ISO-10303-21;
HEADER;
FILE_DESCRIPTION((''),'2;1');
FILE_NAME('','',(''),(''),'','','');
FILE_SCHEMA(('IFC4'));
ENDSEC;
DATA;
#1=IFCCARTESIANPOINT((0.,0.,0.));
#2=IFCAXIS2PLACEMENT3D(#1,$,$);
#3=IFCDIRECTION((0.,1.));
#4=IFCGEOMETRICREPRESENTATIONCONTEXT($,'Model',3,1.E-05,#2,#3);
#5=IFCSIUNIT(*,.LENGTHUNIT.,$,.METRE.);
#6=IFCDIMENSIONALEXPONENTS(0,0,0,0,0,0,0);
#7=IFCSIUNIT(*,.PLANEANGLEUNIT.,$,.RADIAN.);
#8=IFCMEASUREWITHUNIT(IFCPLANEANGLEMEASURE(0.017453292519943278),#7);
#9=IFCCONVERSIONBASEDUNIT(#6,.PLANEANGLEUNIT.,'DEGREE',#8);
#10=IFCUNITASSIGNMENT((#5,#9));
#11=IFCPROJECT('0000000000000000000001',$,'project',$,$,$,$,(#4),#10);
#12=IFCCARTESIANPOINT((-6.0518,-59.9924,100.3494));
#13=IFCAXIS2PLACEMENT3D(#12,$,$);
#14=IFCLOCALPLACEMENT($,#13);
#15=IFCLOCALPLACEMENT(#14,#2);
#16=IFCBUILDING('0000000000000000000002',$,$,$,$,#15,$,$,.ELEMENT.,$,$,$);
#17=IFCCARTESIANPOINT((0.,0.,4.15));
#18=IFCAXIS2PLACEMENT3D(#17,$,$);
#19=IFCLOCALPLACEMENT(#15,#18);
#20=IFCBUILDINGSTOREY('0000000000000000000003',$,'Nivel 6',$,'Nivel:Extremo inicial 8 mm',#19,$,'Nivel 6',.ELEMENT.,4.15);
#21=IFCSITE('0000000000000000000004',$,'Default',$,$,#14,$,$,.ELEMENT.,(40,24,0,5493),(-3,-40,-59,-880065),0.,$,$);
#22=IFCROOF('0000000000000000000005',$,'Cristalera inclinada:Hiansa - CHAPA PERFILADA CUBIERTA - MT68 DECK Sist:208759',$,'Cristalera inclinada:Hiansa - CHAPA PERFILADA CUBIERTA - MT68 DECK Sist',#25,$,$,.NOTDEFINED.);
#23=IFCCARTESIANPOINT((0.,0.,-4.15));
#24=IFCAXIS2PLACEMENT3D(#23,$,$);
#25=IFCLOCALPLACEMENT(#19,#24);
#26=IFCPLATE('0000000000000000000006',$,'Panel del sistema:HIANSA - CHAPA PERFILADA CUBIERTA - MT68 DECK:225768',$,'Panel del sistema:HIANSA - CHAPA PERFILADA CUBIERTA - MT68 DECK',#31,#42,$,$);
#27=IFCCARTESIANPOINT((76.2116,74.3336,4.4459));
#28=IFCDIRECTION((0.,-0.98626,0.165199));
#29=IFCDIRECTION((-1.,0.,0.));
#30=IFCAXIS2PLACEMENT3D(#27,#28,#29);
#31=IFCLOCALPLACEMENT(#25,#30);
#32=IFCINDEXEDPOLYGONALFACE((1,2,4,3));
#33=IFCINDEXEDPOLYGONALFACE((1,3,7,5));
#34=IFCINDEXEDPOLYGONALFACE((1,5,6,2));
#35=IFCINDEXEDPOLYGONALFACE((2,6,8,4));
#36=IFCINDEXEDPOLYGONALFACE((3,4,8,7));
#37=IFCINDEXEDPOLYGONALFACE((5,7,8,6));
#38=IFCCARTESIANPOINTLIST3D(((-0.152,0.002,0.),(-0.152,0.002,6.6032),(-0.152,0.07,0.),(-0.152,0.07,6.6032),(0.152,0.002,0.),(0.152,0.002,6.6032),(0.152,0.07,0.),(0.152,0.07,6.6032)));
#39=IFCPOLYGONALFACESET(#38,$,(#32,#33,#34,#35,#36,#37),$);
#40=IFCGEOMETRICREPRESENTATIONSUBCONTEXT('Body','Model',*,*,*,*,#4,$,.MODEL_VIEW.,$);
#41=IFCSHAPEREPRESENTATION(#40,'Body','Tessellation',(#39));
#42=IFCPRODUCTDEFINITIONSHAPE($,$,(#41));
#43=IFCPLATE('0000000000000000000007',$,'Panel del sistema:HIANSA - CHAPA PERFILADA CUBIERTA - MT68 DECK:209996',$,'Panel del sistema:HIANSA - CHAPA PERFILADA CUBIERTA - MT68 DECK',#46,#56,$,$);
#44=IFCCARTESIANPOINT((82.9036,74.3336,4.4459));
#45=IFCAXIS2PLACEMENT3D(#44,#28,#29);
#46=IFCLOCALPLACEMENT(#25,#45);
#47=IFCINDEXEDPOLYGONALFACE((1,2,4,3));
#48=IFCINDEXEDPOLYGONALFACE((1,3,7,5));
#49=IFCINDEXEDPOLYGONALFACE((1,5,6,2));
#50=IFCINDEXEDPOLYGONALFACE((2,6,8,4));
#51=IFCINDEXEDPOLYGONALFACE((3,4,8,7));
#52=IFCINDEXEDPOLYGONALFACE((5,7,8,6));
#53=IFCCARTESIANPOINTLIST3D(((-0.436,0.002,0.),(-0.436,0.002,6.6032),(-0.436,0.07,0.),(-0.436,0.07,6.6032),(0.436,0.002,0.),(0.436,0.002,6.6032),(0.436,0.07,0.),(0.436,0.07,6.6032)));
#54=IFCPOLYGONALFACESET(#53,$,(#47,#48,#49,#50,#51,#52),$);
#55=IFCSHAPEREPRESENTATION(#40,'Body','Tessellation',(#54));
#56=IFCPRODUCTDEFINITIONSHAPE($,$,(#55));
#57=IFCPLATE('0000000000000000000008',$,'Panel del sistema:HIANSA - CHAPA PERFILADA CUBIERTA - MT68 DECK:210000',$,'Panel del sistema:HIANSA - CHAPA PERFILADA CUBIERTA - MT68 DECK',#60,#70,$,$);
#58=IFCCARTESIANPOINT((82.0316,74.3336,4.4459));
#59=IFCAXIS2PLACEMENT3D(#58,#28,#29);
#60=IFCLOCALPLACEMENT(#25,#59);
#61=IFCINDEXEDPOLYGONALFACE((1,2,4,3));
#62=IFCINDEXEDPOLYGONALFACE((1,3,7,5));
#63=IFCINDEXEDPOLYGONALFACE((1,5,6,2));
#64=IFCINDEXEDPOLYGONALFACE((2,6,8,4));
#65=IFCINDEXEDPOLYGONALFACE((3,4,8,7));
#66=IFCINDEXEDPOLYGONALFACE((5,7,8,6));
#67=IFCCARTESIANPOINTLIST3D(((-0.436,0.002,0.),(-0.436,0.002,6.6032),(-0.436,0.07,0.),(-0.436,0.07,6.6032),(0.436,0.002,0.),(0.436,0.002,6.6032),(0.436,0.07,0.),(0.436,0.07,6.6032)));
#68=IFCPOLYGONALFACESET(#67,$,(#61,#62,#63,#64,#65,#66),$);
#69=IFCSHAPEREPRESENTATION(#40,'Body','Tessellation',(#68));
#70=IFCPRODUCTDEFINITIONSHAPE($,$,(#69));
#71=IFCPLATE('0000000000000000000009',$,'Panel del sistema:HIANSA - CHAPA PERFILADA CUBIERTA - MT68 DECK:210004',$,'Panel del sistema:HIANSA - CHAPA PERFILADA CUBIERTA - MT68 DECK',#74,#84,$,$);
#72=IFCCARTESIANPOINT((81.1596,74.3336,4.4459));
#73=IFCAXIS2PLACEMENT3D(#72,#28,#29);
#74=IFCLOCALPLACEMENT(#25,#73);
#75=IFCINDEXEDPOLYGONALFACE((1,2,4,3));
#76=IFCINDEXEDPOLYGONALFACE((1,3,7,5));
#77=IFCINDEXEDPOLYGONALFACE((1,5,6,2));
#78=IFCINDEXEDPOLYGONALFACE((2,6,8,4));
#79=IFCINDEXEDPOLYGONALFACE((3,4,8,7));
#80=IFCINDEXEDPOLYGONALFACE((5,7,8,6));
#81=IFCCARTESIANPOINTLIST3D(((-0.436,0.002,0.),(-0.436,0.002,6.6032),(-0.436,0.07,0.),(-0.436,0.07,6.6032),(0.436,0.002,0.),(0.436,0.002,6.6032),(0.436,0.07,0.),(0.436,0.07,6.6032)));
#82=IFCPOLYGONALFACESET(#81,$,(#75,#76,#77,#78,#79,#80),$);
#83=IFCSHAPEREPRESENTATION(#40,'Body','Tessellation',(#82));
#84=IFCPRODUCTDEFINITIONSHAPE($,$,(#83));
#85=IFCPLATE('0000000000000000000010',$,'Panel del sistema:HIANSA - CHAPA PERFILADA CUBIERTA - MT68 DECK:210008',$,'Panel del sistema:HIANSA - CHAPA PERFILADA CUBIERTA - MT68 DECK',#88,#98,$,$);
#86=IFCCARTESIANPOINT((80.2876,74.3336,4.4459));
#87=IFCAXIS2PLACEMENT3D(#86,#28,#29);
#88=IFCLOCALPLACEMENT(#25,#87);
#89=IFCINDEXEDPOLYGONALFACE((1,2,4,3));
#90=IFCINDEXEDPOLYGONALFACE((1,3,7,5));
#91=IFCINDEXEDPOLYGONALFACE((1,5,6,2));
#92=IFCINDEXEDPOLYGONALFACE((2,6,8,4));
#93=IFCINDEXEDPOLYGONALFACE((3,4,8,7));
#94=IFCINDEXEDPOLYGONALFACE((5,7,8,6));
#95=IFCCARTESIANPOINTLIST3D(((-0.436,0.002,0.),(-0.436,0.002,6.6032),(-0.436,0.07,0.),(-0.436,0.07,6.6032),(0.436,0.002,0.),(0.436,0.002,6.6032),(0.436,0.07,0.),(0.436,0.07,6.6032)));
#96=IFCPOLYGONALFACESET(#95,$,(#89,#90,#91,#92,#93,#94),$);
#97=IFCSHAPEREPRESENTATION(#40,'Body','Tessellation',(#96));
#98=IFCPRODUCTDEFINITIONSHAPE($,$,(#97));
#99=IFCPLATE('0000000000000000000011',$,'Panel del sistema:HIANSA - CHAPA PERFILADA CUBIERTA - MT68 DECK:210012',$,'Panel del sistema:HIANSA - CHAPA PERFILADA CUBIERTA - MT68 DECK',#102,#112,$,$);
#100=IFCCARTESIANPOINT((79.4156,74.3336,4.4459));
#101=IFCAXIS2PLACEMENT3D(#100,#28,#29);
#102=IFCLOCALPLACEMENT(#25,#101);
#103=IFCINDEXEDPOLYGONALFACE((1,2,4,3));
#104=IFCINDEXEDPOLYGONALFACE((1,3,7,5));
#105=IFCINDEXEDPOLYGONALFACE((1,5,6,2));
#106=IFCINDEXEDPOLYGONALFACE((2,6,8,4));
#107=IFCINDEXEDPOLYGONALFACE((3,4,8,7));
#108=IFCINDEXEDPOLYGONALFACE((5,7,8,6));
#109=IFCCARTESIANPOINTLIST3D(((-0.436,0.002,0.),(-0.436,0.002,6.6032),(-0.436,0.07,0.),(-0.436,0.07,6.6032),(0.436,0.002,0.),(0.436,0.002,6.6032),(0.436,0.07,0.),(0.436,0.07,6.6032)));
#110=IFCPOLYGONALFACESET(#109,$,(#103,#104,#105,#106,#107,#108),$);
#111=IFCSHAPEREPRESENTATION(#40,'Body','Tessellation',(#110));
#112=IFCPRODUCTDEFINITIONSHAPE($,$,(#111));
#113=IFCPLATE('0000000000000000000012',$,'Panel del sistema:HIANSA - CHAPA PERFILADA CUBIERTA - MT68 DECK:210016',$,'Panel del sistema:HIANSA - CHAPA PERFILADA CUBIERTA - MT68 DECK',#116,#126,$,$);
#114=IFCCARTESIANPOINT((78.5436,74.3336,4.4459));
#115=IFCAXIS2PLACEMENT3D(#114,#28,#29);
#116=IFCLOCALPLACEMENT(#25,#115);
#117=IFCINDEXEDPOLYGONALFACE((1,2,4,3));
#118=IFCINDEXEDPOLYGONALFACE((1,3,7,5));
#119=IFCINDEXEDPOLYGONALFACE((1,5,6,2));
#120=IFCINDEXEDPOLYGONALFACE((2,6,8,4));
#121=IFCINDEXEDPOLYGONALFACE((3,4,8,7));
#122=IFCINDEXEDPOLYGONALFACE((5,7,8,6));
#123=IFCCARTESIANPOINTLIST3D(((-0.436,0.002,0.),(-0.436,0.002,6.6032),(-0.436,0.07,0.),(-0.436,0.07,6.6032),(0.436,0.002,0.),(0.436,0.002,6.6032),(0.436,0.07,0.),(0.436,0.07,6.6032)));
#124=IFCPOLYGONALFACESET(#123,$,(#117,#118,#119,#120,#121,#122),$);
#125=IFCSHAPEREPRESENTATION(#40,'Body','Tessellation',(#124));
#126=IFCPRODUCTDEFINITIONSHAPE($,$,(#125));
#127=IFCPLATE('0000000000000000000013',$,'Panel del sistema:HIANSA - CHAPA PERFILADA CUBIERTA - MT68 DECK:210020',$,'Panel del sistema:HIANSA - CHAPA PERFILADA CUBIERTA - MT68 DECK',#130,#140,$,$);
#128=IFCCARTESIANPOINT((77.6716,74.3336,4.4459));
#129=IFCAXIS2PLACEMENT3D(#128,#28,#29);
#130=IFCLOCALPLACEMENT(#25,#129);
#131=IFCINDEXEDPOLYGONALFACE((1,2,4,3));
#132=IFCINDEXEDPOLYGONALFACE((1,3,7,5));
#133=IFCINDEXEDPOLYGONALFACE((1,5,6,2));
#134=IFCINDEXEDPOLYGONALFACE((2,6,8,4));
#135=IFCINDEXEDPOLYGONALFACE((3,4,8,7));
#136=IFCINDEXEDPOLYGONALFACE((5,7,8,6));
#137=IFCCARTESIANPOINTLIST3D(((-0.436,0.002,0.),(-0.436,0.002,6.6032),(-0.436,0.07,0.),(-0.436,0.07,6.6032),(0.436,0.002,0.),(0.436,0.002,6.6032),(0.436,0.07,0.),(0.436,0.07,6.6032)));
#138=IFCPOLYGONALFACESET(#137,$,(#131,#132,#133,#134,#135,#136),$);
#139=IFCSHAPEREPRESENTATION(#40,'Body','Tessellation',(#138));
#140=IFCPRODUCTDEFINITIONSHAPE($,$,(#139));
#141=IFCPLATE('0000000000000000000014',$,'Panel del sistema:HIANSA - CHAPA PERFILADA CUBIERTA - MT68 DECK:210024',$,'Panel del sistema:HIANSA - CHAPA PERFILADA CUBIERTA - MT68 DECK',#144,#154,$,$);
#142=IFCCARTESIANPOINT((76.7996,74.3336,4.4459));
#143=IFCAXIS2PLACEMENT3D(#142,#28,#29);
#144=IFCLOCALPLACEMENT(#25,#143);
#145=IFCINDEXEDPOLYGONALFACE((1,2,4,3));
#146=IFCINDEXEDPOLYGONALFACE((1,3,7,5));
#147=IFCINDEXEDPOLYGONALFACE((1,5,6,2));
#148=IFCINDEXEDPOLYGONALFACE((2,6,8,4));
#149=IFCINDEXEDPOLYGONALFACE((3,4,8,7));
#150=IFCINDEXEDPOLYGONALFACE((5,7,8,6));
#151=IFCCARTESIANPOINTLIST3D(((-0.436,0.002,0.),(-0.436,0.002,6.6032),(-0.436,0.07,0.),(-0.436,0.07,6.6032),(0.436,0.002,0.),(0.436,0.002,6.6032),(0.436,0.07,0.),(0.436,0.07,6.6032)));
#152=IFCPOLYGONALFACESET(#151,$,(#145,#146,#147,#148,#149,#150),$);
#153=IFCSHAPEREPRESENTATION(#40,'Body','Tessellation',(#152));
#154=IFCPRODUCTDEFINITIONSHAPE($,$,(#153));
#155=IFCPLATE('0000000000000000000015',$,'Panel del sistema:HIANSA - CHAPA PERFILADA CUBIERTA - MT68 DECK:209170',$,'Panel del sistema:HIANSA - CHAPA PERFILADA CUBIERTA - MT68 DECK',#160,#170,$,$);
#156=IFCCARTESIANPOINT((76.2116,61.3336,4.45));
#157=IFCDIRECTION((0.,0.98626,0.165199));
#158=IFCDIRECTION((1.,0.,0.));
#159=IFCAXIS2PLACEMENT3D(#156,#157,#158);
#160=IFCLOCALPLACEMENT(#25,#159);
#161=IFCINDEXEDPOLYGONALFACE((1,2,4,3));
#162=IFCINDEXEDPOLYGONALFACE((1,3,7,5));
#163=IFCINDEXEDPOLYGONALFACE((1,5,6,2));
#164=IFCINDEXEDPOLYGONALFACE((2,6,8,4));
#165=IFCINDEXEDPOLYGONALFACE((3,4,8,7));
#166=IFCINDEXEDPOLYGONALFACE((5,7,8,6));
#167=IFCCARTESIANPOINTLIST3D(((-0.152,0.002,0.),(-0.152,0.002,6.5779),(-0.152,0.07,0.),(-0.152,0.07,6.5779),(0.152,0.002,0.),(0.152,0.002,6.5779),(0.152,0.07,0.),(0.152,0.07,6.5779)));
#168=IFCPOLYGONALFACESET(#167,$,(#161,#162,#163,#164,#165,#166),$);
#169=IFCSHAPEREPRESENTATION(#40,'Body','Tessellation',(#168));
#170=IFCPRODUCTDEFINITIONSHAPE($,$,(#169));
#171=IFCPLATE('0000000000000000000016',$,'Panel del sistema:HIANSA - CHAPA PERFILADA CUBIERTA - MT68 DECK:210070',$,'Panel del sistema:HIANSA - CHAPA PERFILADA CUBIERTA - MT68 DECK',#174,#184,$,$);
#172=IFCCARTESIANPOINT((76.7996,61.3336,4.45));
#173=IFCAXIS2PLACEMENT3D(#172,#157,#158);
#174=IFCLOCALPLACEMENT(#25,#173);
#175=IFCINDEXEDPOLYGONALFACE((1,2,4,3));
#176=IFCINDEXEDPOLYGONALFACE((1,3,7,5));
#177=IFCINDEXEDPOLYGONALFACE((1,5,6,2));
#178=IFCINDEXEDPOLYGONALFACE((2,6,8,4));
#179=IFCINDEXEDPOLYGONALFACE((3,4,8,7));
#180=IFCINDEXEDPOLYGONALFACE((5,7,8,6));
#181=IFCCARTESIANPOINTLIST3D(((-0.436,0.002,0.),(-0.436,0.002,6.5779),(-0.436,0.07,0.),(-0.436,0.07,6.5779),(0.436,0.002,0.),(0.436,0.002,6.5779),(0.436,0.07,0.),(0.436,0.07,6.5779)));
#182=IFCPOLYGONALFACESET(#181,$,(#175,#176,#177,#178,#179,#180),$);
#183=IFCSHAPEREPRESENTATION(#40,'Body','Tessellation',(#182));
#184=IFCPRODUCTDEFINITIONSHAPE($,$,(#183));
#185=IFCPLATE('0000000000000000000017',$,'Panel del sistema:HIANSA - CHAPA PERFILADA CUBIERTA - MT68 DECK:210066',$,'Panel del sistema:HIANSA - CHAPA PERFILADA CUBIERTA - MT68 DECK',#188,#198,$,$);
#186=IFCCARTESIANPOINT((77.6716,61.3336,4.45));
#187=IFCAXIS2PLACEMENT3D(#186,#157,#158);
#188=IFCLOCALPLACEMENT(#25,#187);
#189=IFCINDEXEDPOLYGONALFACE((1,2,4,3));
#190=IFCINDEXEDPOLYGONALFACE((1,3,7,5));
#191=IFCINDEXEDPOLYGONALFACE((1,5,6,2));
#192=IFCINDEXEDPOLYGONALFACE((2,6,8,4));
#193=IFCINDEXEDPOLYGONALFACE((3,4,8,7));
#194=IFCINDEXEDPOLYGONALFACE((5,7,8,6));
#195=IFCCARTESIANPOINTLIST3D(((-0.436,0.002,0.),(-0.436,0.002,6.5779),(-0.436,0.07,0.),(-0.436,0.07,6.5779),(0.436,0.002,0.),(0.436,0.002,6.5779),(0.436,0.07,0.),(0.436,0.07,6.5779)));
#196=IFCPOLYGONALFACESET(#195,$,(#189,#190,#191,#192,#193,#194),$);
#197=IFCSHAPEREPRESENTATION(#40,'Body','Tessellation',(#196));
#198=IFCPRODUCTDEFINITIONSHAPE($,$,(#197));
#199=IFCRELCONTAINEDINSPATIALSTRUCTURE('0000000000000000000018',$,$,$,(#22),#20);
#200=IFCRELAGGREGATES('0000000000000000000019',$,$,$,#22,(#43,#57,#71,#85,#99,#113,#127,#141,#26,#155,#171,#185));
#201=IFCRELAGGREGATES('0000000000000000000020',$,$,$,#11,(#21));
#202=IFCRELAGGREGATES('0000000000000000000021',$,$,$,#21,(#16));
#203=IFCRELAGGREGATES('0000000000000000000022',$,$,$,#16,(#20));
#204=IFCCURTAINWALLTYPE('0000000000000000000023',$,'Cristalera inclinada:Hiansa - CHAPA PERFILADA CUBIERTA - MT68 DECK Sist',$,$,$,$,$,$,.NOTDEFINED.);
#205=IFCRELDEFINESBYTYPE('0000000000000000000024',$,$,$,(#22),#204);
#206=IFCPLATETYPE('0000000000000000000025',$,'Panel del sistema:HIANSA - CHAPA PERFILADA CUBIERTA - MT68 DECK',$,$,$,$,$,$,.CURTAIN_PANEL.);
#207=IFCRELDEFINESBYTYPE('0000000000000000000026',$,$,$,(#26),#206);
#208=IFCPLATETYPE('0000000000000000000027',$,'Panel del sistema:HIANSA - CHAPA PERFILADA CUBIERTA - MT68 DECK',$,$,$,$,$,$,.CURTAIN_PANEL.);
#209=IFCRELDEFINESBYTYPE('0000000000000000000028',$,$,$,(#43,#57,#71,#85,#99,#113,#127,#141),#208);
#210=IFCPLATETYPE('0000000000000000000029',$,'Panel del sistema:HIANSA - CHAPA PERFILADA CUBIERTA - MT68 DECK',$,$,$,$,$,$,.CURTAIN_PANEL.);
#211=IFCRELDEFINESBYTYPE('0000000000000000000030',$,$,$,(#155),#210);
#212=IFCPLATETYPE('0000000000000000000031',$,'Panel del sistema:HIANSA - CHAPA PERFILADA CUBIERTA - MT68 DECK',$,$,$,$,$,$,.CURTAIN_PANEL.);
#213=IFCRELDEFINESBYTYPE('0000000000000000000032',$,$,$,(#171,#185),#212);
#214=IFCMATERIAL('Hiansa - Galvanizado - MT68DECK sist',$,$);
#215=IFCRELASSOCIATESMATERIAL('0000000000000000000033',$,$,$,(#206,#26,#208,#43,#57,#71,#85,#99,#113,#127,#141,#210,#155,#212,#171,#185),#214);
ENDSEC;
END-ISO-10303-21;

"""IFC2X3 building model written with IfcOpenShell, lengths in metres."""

from ifc_helpers import new_model, entity, si_unit, converted_unit, direction, frame, origin, origin_2d_with_axis, place, context, subcontext, project, spatial, rectangle, extrude, source, transform, mapped, material, type_object, type_shapes, element, aggregate, save


model = new_model("IFC2X3")

# Units and contexts
model_context = context("Model", 3, precision=1e-05, world=origin(), true_north=direction((0.0, 1.0)))
body_context = subcontext(model_context, "Body", "Model", "MODEL_VIEW")
ifc_project = project(units=[si_unit("LENGTHUNIT", "METRE"), converted_unit("PLANEANGLEUNIT", "DEGREE", entity("IfcPlaneAngleMeasure", 0.017453292519943278), si_unit("PLANEANGLEUNIT", "RADIAN"), dimensions=[0, 0, 0, 0, 0, 0, 0])], contexts=[model_context])

# Site, building, storey
site_placement = place(None, frame((-6.0518, -59.9924, 100.3494)))
site = spatial("IfcSite", under=ifc_project, at=site_placement, Name="Default", CompositionType="ELEMENT", RefLatitude=(40, 24, 0, 5493), RefLongitude=(-3, -40, -59, -880065), RefElevation=0.0)
building_placement = place(site_placement, origin())
building = spatial("IfcBuilding", under=site, at=building_placement, CompositionType="ELEMENT")
storey_placement = place(building_placement, frame((0.0, 0.0, 4.15)))
storey = spatial("IfcBuildingStorey", under=building, at=storey_placement, Name="Nivel 6", ObjectType="Nivel:Extremo inicial 8 mm", LongName="Nivel 6", CompositionType="ELEMENT", Elevation=4.15)

# Roof, plates
curtain_wall_type = type_object("IfcCurtainWallType", Name="Cristalera inclinada:Hiansa - CHAPA PERFILADA CUBIERTA - MT68 DECK Sist", PredefinedType="NOTDEFINED")
roof_placement = place(storey_placement, frame((0.0, 0.0, -4.15)))
roof = element("IfcRoof", 1, at=roof_placement, inside=storey, type_object=curtain_wall_type, Name="Cristalera inclinada:Hiansa - CHAPA PERFILADA CUBIERTA - MT68 DECK Sist:208759", ObjectType="Cristalera inclinada:Hiansa - CHAPA PERFILADA CUBIERTA - MT68 DECK Sist", ShapeType="NOTDEFINED")
ifc_material_1 = material(Name="Hiansa - Galvanizado - MT68DECK sist")
plate_type_1 = type_object("IfcPlateType", Name="Panel del sistema:HIANSA - CHAPA PERFILADA CUBIERTA - MT68 DECK", PredefinedType="CURTAIN_PANEL", material=ifc_material_1)
shared_shape_1 = source(origin(), body_context, "Body", "SweptSolid", [
    extrude(rectangle(XDim=0.068, YDim=0.304, at=origin_2d_with_axis()), frame((0.0, 0.036, 0.0), z_axis=(0.0, 0.0, 1.0), x_axis=(0.0, 1.0, 0.0)), (0.0, 0.0, 1.0), 6.6032),
])
type_shapes(plate_type_1, [shared_shape_1])
plate_1_placement = place(roof_placement, frame((76.2116, 74.3336, 4.4459), z_axis=(0.0, -0.98626, 0.165199), x_axis=(-1.0, 0.0, 0.0)))
plate_1 = element("IfcPlate", 2, at=plate_1_placement, type_object=plate_type_1, material=ifc_material_1, Name="Panel del sistema:HIANSA - CHAPA PERFILADA CUBIERTA - MT68 DECK:225768", ObjectType="Panel del sistema:HIANSA - CHAPA PERFILADA CUBIERTA - MT68 DECK", context=body_context, shape_type="MappedRepresentation", body=[
    mapped(shared_shape_1, transform((0.0, 0.0, 0.0), scale=1.0)),
])
plate_type_2 = type_object("IfcPlateType", Name="Panel del sistema:HIANSA - CHAPA PERFILADA CUBIERTA - MT68 DECK", PredefinedType="CURTAIN_PANEL", material=ifc_material_1)
shared_shape_2 = source(origin(), body_context, "Body", "SweptSolid", [
    extrude(rectangle(XDim=0.068, YDim=0.872, at=origin_2d_with_axis()), frame((0.0, 0.036, 0.0), z_axis=(0.0, 0.0, 1.0), x_axis=(0.0, 1.0, 0.0)), (0.0, 0.0, 1.0), 6.6032),
])
type_shapes(plate_type_2, [shared_shape_2])
plate_2_placement = place(roof_placement, frame((82.9036, 74.3336, 4.4459), z_axis=(0.0, -0.98626, 0.165199), x_axis=(-1.0, 0.0, 0.0)))
plate_2 = element("IfcPlate", 3, at=plate_2_placement, type_object=plate_type_2, material=ifc_material_1, Name="Panel del sistema:HIANSA - CHAPA PERFILADA CUBIERTA - MT68 DECK:209996", ObjectType="Panel del sistema:HIANSA - CHAPA PERFILADA CUBIERTA - MT68 DECK", context=body_context, shape_type="MappedRepresentation", body=[
    mapped(shared_shape_2, transform((0.0, 0.0, 0.0), scale=1.0)),
])
plate_3_placement = place(roof_placement, frame((82.0316, 74.3336, 4.4459), z_axis=(0.0, -0.98626, 0.165199), x_axis=(-1.0, 0.0, 0.0)))
plate_3 = element("IfcPlate", 4, at=plate_3_placement, type_object=plate_type_2, material=ifc_material_1, Name="Panel del sistema:HIANSA - CHAPA PERFILADA CUBIERTA - MT68 DECK:210000", ObjectType="Panel del sistema:HIANSA - CHAPA PERFILADA CUBIERTA - MT68 DECK", context=body_context, shape_type="MappedRepresentation", body=[
    mapped(shared_shape_2, transform((0.0, 0.0, 0.0), scale=1.0)),
])
plate_4_placement = place(roof_placement, frame((81.1596, 74.3336, 4.4459), z_axis=(0.0, -0.98626, 0.165199), x_axis=(-1.0, 0.0, 0.0)))
plate_4 = element("IfcPlate", 5, at=plate_4_placement, type_object=plate_type_2, material=ifc_material_1, Name="Panel del sistema:HIANSA - CHAPA PERFILADA CUBIERTA - MT68 DECK:210004", ObjectType="Panel del sistema:HIANSA - CHAPA PERFILADA CUBIERTA - MT68 DECK", context=body_context, shape_type="MappedRepresentation", body=[
    mapped(shared_shape_2, transform((0.0, 0.0, 0.0), scale=1.0)),
])
plate_5_placement = place(roof_placement, frame((80.2876, 74.3336, 4.4459), z_axis=(0.0, -0.98626, 0.165199), x_axis=(-1.0, 0.0, 0.0)))
plate_5 = element("IfcPlate", 6, at=plate_5_placement, type_object=plate_type_2, material=ifc_material_1, Name="Panel del sistema:HIANSA - CHAPA PERFILADA CUBIERTA - MT68 DECK:210008", ObjectType="Panel del sistema:HIANSA - CHAPA PERFILADA CUBIERTA - MT68 DECK", context=body_context, shape_type="MappedRepresentation", body=[
    mapped(shared_shape_2, transform((0.0, 0.0, 0.0), scale=1.0)),
])
plate_6_placement = place(roof_placement, frame((79.4156, 74.3336, 4.4459), z_axis=(0.0, -0.98626, 0.165199), x_axis=(-1.0, 0.0, 0.0)))
plate_6 = element("IfcPlate", 7, at=plate_6_placement, type_object=plate_type_2, material=ifc_material_1, Name="Panel del sistema:HIANSA - CHAPA PERFILADA CUBIERTA - MT68 DECK:210012", ObjectType="Panel del sistema:HIANSA - CHAPA PERFILADA CUBIERTA - MT68 DECK", context=body_context, shape_type="MappedRepresentation", body=[
    mapped(shared_shape_2, transform((0.0, 0.0, 0.0), scale=1.0)),
])
plate_7_placement = place(roof_placement, frame((78.5436, 74.3336, 4.4459), z_axis=(0.0, -0.98626, 0.165199), x_axis=(-1.0, 0.0, 0.0)))
plate_7 = element("IfcPlate", 8, at=plate_7_placement, type_object=plate_type_2, material=ifc_material_1, Name="Panel del sistema:HIANSA - CHAPA PERFILADA CUBIERTA - MT68 DECK:210016", ObjectType="Panel del sistema:HIANSA - CHAPA PERFILADA CUBIERTA - MT68 DECK", context=body_context, shape_type="MappedRepresentation", body=[
    mapped(shared_shape_2, transform((0.0, 0.0, 0.0), scale=1.0)),
])
plate_8_placement = place(roof_placement, frame((77.6716, 74.3336, 4.4459), z_axis=(0.0, -0.98626, 0.165199), x_axis=(-1.0, 0.0, 0.0)))
plate_8 = element("IfcPlate", 9, at=plate_8_placement, type_object=plate_type_2, material=ifc_material_1, Name="Panel del sistema:HIANSA - CHAPA PERFILADA CUBIERTA - MT68 DECK:210020", ObjectType="Panel del sistema:HIANSA - CHAPA PERFILADA CUBIERTA - MT68 DECK", context=body_context, shape_type="MappedRepresentation", body=[
    mapped(shared_shape_2, transform((0.0, 0.0, 0.0), scale=1.0)),
])
plate_9_placement = place(roof_placement, frame((76.7996, 74.3336, 4.4459), z_axis=(0.0, -0.98626, 0.165199), x_axis=(-1.0, 0.0, 0.0)))
plate_9 = element("IfcPlate", 10, at=plate_9_placement, type_object=plate_type_2, material=ifc_material_1, Name="Panel del sistema:HIANSA - CHAPA PERFILADA CUBIERTA - MT68 DECK:210024", ObjectType="Panel del sistema:HIANSA - CHAPA PERFILADA CUBIERTA - MT68 DECK", context=body_context, shape_type="MappedRepresentation", body=[
    mapped(shared_shape_2, transform((0.0, 0.0, 0.0), scale=1.0)),
])
plate_type_3 = type_object("IfcPlateType", Name="Panel del sistema:HIANSA - CHAPA PERFILADA CUBIERTA - MT68 DECK", PredefinedType="CURTAIN_PANEL", material=ifc_material_1)
shared_shape_3 = source(origin(), body_context, "Body", "SweptSolid", [
    extrude(rectangle(XDim=0.068, YDim=0.304, at=origin_2d_with_axis()), frame((0.0, 0.036, 0.0), z_axis=(0.0, 0.0, 1.0), x_axis=(0.0, 1.0, 0.0)), (0.0, 0.0, 1.0), 6.5779),
])
type_shapes(plate_type_3, [shared_shape_3])
plate_10_placement = place(roof_placement, frame((76.2116, 61.3336, 4.45), z_axis=(0.0, 0.98626, 0.165199), x_axis=(1.0, 0.0, 0.0)))
plate_10 = element("IfcPlate", 11, at=plate_10_placement, type_object=plate_type_3, material=ifc_material_1, Name="Panel del sistema:HIANSA - CHAPA PERFILADA CUBIERTA - MT68 DECK:209170", ObjectType="Panel del sistema:HIANSA - CHAPA PERFILADA CUBIERTA - MT68 DECK", context=body_context, shape_type="MappedRepresentation", body=[
    mapped(shared_shape_3, transform((0.0, 0.0, 0.0), scale=1.0)),
])
plate_type_4 = type_object("IfcPlateType", Name="Panel del sistema:HIANSA - CHAPA PERFILADA CUBIERTA - MT68 DECK", PredefinedType="CURTAIN_PANEL", material=ifc_material_1)
shared_shape_4 = source(origin(), body_context, "Body", "SweptSolid", [
    extrude(rectangle(XDim=0.068, YDim=0.872, at=origin_2d_with_axis()), frame((0.0, 0.036, 0.0), z_axis=(0.0, 0.0, 1.0), x_axis=(0.0, 1.0, 0.0)), (0.0, 0.0, 1.0), 6.5779),
])
type_shapes(plate_type_4, [shared_shape_4])
plate_11_placement = place(roof_placement, frame((76.7996, 61.3336, 4.45), z_axis=(0.0, 0.98626, 0.165199), x_axis=(1.0, 0.0, 0.0)))
plate_11 = element("IfcPlate", 12, at=plate_11_placement, type_object=plate_type_4, material=ifc_material_1, Name="Panel del sistema:HIANSA - CHAPA PERFILADA CUBIERTA - MT68 DECK:210070", ObjectType="Panel del sistema:HIANSA - CHAPA PERFILADA CUBIERTA - MT68 DECK", context=body_context, shape_type="MappedRepresentation", body=[
    mapped(shared_shape_4, transform((0.0, 0.0, 0.0), scale=1.0)),
])
plate_12_placement = place(roof_placement, frame((77.6716, 61.3336, 4.45), z_axis=(0.0, 0.98626, 0.165199), x_axis=(1.0, 0.0, 0.0)))
plate_12 = element("IfcPlate", 13, at=plate_12_placement, type_object=plate_type_4, material=ifc_material_1, Name="Panel del sistema:HIANSA - CHAPA PERFILADA CUBIERTA - MT68 DECK:210066", ObjectType="Panel del sistema:HIANSA - CHAPA PERFILADA CUBIERTA - MT68 DECK", context=body_context, shape_type="MappedRepresentation", body=[
    mapped(shared_shape_4, transform((0.0, 0.0, 0.0), scale=1.0)),
])
aggregate(roof, [plate_2, plate_3, plate_4, plate_5, plate_6, plate_7, plate_8, plate_9, plate_1, plate_10, plate_11, plate_12])

save(model, "model.ifc")
